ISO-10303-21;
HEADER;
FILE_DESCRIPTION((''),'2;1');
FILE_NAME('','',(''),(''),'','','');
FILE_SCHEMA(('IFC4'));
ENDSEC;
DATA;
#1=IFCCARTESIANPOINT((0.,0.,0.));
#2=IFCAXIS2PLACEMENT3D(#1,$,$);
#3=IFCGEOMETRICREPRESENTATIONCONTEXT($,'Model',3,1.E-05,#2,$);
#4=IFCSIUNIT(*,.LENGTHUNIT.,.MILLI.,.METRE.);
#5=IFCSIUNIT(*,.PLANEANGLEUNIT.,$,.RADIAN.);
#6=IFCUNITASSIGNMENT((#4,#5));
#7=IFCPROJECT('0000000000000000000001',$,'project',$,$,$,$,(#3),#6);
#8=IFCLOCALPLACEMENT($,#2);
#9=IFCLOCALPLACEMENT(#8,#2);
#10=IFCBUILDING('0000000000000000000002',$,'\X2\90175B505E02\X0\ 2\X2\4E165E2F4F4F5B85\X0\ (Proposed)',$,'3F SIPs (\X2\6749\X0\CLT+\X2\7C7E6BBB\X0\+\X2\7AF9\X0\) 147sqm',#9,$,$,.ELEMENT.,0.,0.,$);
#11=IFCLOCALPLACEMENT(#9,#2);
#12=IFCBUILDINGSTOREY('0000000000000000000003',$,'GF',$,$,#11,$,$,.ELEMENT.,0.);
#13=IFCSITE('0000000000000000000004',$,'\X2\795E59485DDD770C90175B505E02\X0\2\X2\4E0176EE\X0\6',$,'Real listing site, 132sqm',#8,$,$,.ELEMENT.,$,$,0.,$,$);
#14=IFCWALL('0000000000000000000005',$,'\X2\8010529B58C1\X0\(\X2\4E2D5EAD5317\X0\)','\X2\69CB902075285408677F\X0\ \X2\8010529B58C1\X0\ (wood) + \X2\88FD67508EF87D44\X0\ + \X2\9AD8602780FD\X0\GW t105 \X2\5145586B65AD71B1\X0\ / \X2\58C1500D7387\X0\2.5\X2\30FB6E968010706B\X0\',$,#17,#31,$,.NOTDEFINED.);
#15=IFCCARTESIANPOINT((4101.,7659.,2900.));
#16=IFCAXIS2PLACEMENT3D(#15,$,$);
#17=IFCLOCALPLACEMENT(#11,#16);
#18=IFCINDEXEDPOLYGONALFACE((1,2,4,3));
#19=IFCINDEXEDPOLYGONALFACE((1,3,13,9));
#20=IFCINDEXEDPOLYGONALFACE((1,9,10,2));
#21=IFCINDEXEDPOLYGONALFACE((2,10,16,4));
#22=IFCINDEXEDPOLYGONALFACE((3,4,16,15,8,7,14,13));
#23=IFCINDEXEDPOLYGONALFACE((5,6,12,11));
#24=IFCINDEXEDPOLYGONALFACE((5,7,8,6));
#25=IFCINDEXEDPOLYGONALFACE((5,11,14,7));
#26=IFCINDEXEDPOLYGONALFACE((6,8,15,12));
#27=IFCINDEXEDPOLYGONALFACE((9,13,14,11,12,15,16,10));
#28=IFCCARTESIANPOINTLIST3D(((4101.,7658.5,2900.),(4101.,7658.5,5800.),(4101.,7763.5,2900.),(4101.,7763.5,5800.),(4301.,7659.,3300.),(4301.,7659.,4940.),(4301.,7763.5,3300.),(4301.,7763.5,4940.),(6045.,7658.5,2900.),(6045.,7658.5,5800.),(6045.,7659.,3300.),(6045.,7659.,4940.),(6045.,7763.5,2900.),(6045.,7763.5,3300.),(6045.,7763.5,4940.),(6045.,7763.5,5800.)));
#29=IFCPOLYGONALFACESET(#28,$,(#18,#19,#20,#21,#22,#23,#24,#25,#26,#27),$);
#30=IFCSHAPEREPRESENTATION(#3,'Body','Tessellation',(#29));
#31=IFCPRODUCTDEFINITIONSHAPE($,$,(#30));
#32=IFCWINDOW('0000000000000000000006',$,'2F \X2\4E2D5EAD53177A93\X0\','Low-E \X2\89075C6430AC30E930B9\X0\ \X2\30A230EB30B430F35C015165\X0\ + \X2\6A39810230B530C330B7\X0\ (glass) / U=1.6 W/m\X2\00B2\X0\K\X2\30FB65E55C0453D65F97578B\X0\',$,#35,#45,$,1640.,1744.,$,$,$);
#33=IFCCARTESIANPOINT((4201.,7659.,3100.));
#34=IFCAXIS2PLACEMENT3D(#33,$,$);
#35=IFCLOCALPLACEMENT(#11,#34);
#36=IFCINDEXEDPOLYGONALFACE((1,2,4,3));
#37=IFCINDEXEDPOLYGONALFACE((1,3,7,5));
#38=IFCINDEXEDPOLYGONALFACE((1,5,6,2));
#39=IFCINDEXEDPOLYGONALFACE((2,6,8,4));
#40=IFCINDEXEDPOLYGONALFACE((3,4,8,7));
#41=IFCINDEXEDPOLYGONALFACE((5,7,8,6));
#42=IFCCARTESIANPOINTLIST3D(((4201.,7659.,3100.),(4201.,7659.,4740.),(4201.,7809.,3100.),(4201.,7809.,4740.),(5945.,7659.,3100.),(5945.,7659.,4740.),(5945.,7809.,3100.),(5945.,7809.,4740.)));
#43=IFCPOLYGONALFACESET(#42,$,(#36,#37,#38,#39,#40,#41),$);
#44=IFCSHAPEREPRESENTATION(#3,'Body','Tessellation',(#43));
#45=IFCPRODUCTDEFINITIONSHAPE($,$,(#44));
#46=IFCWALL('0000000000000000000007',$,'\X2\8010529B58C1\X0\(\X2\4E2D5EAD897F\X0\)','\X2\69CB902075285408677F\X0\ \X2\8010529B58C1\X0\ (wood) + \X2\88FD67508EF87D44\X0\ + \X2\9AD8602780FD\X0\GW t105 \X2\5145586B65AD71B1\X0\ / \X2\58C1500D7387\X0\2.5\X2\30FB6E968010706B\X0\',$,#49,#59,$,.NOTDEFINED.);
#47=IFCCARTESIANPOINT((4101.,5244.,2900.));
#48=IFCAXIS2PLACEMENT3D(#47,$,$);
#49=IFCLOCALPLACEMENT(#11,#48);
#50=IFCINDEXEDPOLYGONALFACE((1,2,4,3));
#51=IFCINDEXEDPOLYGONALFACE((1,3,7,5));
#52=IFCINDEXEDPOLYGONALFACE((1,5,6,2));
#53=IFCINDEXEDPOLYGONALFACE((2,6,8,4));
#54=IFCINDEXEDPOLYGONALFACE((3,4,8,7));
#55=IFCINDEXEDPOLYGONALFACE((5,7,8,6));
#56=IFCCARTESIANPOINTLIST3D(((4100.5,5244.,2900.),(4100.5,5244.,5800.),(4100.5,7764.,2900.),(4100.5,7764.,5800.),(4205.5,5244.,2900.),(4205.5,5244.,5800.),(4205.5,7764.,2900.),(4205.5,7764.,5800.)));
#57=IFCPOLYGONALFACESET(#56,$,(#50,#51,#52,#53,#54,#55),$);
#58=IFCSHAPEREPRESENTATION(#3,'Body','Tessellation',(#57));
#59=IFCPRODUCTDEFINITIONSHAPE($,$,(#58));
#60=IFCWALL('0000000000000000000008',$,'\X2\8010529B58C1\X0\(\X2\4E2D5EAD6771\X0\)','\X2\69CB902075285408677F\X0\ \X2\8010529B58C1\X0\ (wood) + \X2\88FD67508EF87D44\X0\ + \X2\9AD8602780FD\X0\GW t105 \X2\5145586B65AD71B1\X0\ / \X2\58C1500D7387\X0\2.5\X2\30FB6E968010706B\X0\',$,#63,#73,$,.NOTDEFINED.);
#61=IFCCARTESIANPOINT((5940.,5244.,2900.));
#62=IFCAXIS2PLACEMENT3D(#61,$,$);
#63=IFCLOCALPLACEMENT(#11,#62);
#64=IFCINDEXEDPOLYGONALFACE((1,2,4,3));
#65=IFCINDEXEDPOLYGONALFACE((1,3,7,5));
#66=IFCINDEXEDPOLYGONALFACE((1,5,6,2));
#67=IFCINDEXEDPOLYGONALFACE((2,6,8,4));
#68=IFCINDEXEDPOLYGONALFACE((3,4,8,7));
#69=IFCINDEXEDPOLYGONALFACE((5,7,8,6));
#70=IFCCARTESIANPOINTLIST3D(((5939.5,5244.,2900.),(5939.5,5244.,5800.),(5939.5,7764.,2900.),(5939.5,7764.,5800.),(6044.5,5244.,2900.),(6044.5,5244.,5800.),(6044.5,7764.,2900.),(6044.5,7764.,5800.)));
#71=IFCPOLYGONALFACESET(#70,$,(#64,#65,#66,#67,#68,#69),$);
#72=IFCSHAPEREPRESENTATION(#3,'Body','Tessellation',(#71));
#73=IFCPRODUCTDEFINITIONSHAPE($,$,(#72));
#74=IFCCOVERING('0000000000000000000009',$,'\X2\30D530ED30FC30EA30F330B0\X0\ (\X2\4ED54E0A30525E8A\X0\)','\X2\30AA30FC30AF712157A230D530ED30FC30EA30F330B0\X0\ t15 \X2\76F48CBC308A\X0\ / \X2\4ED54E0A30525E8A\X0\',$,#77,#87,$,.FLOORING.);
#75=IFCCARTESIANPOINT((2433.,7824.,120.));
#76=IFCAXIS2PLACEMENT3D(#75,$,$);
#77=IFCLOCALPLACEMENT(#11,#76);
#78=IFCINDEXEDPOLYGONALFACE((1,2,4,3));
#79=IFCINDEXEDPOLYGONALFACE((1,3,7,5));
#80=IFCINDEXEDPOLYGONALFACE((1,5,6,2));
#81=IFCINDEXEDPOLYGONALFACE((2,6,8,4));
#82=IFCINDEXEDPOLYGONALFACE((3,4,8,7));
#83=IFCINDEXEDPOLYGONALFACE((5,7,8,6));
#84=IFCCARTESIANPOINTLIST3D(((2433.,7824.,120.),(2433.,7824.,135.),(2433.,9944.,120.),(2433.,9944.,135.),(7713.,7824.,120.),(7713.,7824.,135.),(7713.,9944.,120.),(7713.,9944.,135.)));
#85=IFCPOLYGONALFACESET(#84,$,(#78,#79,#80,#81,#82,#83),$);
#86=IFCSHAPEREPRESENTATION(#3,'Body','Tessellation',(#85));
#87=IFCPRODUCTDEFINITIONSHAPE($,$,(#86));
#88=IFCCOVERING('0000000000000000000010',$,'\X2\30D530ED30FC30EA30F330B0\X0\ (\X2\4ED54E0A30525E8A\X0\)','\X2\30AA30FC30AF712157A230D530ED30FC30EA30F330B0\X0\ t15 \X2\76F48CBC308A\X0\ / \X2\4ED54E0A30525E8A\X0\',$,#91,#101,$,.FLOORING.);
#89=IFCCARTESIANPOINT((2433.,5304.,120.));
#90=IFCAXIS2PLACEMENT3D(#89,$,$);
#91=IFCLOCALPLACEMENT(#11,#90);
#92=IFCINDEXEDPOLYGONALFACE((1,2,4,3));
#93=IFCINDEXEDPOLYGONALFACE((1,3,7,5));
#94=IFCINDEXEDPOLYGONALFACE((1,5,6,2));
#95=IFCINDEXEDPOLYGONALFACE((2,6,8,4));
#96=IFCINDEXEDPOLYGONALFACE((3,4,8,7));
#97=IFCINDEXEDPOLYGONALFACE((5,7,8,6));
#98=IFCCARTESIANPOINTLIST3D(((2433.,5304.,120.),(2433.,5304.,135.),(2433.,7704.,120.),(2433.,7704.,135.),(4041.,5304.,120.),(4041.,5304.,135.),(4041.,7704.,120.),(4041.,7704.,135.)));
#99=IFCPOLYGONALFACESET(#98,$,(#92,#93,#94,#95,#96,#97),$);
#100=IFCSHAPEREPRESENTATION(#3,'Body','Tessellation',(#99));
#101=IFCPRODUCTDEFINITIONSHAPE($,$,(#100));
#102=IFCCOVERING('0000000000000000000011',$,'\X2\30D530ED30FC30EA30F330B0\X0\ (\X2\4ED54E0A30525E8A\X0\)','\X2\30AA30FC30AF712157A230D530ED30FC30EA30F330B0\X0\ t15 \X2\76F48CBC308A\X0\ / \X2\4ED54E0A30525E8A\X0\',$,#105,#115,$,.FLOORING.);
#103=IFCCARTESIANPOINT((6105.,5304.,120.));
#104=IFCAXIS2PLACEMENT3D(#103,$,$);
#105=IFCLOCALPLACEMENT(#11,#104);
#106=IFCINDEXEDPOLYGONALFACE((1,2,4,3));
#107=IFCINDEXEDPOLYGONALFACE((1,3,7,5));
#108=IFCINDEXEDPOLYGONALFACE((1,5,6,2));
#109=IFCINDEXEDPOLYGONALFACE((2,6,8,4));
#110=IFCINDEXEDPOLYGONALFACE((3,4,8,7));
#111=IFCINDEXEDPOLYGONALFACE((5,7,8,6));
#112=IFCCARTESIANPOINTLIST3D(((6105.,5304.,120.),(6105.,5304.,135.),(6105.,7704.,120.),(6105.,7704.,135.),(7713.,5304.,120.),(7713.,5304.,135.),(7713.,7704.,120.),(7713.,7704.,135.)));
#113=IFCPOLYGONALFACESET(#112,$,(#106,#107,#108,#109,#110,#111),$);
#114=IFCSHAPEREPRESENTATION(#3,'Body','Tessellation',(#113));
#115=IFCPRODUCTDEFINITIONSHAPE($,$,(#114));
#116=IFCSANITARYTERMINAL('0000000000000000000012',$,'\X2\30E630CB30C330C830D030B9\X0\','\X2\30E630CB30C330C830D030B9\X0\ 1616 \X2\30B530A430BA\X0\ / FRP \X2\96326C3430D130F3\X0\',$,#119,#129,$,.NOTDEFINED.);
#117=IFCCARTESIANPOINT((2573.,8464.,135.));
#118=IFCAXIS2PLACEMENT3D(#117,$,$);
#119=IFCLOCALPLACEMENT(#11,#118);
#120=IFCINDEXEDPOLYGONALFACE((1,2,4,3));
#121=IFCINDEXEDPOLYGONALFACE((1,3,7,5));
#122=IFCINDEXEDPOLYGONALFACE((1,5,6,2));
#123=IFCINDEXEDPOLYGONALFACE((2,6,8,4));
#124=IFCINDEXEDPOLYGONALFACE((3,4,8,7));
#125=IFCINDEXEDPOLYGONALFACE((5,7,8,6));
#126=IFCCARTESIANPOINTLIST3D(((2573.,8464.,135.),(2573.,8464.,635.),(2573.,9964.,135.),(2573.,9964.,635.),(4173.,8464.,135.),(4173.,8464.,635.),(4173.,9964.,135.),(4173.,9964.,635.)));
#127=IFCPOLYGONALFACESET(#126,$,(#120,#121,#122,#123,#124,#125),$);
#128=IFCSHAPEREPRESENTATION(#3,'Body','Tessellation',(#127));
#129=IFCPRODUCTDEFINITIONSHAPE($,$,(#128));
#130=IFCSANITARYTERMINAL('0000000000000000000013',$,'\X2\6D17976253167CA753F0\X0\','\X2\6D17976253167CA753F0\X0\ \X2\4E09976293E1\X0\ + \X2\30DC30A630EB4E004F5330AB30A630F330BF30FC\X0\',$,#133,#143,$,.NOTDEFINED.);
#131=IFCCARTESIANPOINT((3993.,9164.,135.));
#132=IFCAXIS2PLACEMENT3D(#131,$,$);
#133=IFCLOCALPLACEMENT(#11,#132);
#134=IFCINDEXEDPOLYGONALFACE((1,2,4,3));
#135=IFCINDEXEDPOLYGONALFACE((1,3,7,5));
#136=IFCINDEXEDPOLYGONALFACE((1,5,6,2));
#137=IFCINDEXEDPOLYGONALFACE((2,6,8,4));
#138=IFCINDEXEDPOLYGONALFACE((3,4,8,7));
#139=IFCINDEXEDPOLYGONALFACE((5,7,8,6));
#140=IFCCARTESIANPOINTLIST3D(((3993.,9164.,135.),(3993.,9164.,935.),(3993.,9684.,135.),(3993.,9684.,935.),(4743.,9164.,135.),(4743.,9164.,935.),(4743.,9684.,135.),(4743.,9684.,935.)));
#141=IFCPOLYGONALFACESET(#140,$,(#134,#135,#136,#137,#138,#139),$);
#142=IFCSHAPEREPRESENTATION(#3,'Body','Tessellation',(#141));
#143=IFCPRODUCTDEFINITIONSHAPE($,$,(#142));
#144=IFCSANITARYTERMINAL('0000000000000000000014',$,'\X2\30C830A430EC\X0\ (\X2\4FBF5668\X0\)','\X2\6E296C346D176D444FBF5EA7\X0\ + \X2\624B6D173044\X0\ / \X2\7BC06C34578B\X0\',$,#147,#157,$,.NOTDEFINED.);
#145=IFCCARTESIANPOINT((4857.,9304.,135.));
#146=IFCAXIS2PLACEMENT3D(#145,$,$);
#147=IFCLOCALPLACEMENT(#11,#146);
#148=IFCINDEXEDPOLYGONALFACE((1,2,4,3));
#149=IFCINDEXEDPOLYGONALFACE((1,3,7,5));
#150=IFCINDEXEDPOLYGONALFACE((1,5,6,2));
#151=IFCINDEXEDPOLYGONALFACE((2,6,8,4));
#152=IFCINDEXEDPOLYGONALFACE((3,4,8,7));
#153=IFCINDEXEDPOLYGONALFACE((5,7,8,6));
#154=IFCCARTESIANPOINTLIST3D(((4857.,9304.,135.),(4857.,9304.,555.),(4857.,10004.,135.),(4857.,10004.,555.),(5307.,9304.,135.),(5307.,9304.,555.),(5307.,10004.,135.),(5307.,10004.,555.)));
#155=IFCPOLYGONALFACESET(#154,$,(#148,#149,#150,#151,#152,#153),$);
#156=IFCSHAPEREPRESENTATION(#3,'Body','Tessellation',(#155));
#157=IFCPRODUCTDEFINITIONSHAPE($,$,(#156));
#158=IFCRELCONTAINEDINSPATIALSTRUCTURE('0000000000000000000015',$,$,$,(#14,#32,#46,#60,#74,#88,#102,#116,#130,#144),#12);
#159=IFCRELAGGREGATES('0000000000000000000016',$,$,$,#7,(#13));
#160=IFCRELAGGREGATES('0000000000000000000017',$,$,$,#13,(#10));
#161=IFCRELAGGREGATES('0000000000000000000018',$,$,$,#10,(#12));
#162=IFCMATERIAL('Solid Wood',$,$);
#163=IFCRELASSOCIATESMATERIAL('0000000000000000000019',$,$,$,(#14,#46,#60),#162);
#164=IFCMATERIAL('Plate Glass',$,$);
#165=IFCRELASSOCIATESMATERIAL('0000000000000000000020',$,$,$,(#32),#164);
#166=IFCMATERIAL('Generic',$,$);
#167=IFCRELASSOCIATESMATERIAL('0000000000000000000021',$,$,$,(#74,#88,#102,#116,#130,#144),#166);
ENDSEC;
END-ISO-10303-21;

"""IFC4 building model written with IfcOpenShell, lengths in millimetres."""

from ifc_helpers import new_model, si_unit, frame, frame_2d, origin, place, context, project, spatial, rectangle, extrude, material, element, fill, save


model = new_model("IFC4")

# Units and contexts
model_context = context("Model", 3, precision=1e-05, world=origin())
ifc_project = project(units=[si_unit("LENGTHUNIT", "METRE", prefix="MILLI"), si_unit("PLANEANGLEUNIT", "RADIAN")], contexts=[model_context])

# Site, building, storey
site_placement = place(None, origin())
site = spatial("IfcSite", under=ifc_project, at=site_placement, Name="神奈川県逗子市2丁目6", ObjectType="Real listing site, 132sqm", CompositionType="ELEMENT", RefElevation=0.0)
building_placement = place(site_placement, origin())
building = spatial("IfcBuilding", under=site, at=building_placement, Name="逗子市 2世帯住宅 (Proposed)", ObjectType="3F SIPs (杉CLT+籾殻+竹) 147sqm", CompositionType="ELEMENT", ElevationOfRefHeight=0.0, ElevationOfTerrain=0.0)
storey_placement = place(building_placement, origin())
storey = spatial("IfcBuildingStorey", under=building, at=storey_placement, Name="GF", CompositionType="ELEMENT", Elevation=0.0)

# Shared definitions
ifc_material_1 = material(Name="Solid Wood")

# Shared definitions
ifc_material_2 = material(Name="Plate Glass")

# Wall, opening, window
wall_1_placement = place(storey_placement, frame((4101.0, 7659.0, 2900.0)))
wall_1 = element("IfcWall", 1, at=wall_1_placement, inside=storey, material=ifc_material_1, Name="耐力壁(中庭北)", Description="構造用合板 耐力壁 (wood) + 製材軸組 + 高性能GW t105 充填断熱 / 壁倍率2.5・準耐火", PredefinedType="NOTDEFINED", context=model_context, shape_type="SweptSolid", body=[
    extrude(rectangle(XDim=1944.0, YDim=105.0, at=frame_2d((972.0, 52.0))), frame((4101.0, 7659.0, 2900.0)), (0.0, 0.0, 1.0), 2900.0),
])
opening_1_placement = place(storey_placement, frame((4201.0, 7659.0, 3100.0)))
opening_1 = element("IfcOpeningElement", 2, at=opening_1_placement, cuts=wall_1, PredefinedType="NOTDEFINED", context=model_context, shape_type="SweptSolid", body=[
    extrude(rectangle(XDim=1744.0, YDim=150.0, at=frame_2d((872.0, 75.0))), frame((4201.0, 7659.0, 3100.0)), (0.0, 0.0, 1.0), 1640.0),
])
window_1_placement = place(storey_placement, frame((4201.0, 7659.0, 3100.0)))
window_1 = element("IfcWindow", 3, at=window_1_placement, inside=storey, material=ifc_material_2, Name="2F 中庭北窓", Description="Low-E 複層ガラス アルゴン封入 + 樹脂サッシ (glass) / U=1.6 W/m²K・日射取得型", OverallHeight=1640.0, OverallWidth=1744.0, context=model_context, shape_type="SweptSolid", body=[
    extrude(rectangle(XDim=1744.0, YDim=150.0, at=frame_2d((872.0, 75.0))), frame((4201.0, 7659.0, 3100.0)), (0.0, 0.0, 1.0), 1640.0),
])
fill(opening_1, window_1)

# Walls
wall_2_placement = place(storey_placement, frame((4101.0, 5244.0, 2900.0)))
element("IfcWall", 4, at=wall_2_placement, inside=storey, material=ifc_material_1, Name="耐力壁(中庭西)", Description="構造用合板 耐力壁 (wood) + 製材軸組 + 高性能GW t105 充填断熱 / 壁倍率2.5・準耐火", PredefinedType="NOTDEFINED", context=model_context, shape_type="SweptSolid", body=[
    extrude(rectangle(XDim=105.0, YDim=2520.0, at=frame_2d((52.0, 1260.0))), frame((4101.0, 5244.0, 2900.0)), (0.0, 0.0, 1.0), 2900.0),
])
wall_3_placement = place(storey_placement, frame((5940.0, 5244.0, 2900.0)))
element("IfcWall", 5, at=wall_3_placement, inside=storey, material=ifc_material_1, Name="耐力壁(中庭東)", Description="構造用合板 耐力壁 (wood) + 製材軸組 + 高性能GW t105 充填断熱 / 壁倍率2.5・準耐火", PredefinedType="NOTDEFINED", context=model_context, shape_type="SweptSolid", body=[
    extrude(rectangle(XDim=105.0, YDim=2520.0, at=frame_2d((52.0, 1260.0))), frame((5940.0, 5244.0, 2900.0)), (0.0, 0.0, 1.0), 2900.0),
])

# Coverings
ifc_material_3 = material(Name="Generic")
covering_1_placement = place(storey_placement, frame((2433.0, 7824.0, 120.0)))
element("IfcCovering", 6, at=covering_1_placement, inside=storey, material=ifc_material_3, Name="フローリング (仕上げ床)", Description="オーク無垢フローリング t15 直貼り / 仕上げ床", PredefinedType="FLOORING", context=model_context, shape_type="SweptSolid", body=[
    extrude(rectangle(XDim=5280.0, YDim=2120.0, at=frame_2d((2640.0, 1060.0))), frame((2433.0, 7824.0, 120.0)), (0.0, 0.0, 1.0), 15.0),
])
covering_2_placement = place(storey_placement, frame((2433.0, 5304.0, 120.0)))
element("IfcCovering", 7, at=covering_2_placement, inside=storey, material=ifc_material_3, Name="フローリング (仕上げ床)", Description="オーク無垢フローリング t15 直貼り / 仕上げ床", PredefinedType="FLOORING", context=model_context, shape_type="SweptSolid", body=[
    extrude(rectangle(XDim=1608.0, YDim=2400.0, at=frame_2d((804.0, 1200.0))), frame((2433.0, 5304.0, 120.0)), (0.0, 0.0, 1.0), 15.0),
])
covering_3_placement = place(storey_placement, frame((6105.0, 5304.0, 120.0)))
element("IfcCovering", 8, at=covering_3_placement, inside=storey, material=ifc_material_3, Name="フローリング (仕上げ床)", Description="オーク無垢フローリング t15 直貼り / 仕上げ床", PredefinedType="FLOORING", context=model_context, shape_type="SweptSolid", body=[
    extrude(rectangle(XDim=1608.0, YDim=2400.0, at=frame_2d((804.0, 1200.0))), frame((6105.0, 5304.0, 120.0)), (0.0, 0.0, 1.0), 15.0),
])

# Sanitary terminals
sanitary_terminal_1_placement = place(storey_placement, frame((2573.0, 8464.0, 135.0)))
element("IfcSanitaryTerminal", 9, at=sanitary_terminal_1_placement, inside=storey, material=ifc_material_3, Name="ユニットバス", Description="ユニットバス 1616 サイズ / FRP 防水パン", PredefinedType="NOTDEFINED", context=model_context, shape_type="SweptSolid", body=[
    extrude(rectangle(XDim=1600.0, YDim=1500.0, at=frame_2d((800.0, 750.0))), frame((2573.0, 8464.0, 135.0)), (0.0, 0.0, 1.0), 500.0),
])
sanitary_terminal_2_placement = place(storey_placement, frame((3993.0, 9164.0, 135.0)))
element("IfcSanitaryTerminal", 10, at=sanitary_terminal_2_placement, inside=storey, material=ifc_material_3, Name="洗面化粧台", Description="洗面化粧台 三面鏡 + ボウル一体カウンター", PredefinedType="NOTDEFINED", context=model_context, shape_type="SweptSolid", body=[
    extrude(rectangle(XDim=750.0, YDim=520.0, at=frame_2d((375.0, 260.0))), frame((3993.0, 9164.0, 135.0)), (0.0, 0.0, 1.0), 800.0),
])
sanitary_terminal_3_placement = place(storey_placement, frame((4857.0, 9304.0, 135.0)))
element("IfcSanitaryTerminal", 11, at=sanitary_terminal_3_placement, inside=storey, material=ifc_material_3, Name="トイレ (便器)", Description="温水洗浄便座 + 手洗い / 節水型", PredefinedType="NOTDEFINED", context=model_context, shape_type="SweptSolid", body=[
    extrude(rectangle(XDim=450.0, YDim=700.0, at=frame_2d((225.0, 350.0))), frame((4857.0, 9304.0, 135.0)), (0.0, 0.0, 1.0), 420.0),
])

save(model, "model.ifc")
